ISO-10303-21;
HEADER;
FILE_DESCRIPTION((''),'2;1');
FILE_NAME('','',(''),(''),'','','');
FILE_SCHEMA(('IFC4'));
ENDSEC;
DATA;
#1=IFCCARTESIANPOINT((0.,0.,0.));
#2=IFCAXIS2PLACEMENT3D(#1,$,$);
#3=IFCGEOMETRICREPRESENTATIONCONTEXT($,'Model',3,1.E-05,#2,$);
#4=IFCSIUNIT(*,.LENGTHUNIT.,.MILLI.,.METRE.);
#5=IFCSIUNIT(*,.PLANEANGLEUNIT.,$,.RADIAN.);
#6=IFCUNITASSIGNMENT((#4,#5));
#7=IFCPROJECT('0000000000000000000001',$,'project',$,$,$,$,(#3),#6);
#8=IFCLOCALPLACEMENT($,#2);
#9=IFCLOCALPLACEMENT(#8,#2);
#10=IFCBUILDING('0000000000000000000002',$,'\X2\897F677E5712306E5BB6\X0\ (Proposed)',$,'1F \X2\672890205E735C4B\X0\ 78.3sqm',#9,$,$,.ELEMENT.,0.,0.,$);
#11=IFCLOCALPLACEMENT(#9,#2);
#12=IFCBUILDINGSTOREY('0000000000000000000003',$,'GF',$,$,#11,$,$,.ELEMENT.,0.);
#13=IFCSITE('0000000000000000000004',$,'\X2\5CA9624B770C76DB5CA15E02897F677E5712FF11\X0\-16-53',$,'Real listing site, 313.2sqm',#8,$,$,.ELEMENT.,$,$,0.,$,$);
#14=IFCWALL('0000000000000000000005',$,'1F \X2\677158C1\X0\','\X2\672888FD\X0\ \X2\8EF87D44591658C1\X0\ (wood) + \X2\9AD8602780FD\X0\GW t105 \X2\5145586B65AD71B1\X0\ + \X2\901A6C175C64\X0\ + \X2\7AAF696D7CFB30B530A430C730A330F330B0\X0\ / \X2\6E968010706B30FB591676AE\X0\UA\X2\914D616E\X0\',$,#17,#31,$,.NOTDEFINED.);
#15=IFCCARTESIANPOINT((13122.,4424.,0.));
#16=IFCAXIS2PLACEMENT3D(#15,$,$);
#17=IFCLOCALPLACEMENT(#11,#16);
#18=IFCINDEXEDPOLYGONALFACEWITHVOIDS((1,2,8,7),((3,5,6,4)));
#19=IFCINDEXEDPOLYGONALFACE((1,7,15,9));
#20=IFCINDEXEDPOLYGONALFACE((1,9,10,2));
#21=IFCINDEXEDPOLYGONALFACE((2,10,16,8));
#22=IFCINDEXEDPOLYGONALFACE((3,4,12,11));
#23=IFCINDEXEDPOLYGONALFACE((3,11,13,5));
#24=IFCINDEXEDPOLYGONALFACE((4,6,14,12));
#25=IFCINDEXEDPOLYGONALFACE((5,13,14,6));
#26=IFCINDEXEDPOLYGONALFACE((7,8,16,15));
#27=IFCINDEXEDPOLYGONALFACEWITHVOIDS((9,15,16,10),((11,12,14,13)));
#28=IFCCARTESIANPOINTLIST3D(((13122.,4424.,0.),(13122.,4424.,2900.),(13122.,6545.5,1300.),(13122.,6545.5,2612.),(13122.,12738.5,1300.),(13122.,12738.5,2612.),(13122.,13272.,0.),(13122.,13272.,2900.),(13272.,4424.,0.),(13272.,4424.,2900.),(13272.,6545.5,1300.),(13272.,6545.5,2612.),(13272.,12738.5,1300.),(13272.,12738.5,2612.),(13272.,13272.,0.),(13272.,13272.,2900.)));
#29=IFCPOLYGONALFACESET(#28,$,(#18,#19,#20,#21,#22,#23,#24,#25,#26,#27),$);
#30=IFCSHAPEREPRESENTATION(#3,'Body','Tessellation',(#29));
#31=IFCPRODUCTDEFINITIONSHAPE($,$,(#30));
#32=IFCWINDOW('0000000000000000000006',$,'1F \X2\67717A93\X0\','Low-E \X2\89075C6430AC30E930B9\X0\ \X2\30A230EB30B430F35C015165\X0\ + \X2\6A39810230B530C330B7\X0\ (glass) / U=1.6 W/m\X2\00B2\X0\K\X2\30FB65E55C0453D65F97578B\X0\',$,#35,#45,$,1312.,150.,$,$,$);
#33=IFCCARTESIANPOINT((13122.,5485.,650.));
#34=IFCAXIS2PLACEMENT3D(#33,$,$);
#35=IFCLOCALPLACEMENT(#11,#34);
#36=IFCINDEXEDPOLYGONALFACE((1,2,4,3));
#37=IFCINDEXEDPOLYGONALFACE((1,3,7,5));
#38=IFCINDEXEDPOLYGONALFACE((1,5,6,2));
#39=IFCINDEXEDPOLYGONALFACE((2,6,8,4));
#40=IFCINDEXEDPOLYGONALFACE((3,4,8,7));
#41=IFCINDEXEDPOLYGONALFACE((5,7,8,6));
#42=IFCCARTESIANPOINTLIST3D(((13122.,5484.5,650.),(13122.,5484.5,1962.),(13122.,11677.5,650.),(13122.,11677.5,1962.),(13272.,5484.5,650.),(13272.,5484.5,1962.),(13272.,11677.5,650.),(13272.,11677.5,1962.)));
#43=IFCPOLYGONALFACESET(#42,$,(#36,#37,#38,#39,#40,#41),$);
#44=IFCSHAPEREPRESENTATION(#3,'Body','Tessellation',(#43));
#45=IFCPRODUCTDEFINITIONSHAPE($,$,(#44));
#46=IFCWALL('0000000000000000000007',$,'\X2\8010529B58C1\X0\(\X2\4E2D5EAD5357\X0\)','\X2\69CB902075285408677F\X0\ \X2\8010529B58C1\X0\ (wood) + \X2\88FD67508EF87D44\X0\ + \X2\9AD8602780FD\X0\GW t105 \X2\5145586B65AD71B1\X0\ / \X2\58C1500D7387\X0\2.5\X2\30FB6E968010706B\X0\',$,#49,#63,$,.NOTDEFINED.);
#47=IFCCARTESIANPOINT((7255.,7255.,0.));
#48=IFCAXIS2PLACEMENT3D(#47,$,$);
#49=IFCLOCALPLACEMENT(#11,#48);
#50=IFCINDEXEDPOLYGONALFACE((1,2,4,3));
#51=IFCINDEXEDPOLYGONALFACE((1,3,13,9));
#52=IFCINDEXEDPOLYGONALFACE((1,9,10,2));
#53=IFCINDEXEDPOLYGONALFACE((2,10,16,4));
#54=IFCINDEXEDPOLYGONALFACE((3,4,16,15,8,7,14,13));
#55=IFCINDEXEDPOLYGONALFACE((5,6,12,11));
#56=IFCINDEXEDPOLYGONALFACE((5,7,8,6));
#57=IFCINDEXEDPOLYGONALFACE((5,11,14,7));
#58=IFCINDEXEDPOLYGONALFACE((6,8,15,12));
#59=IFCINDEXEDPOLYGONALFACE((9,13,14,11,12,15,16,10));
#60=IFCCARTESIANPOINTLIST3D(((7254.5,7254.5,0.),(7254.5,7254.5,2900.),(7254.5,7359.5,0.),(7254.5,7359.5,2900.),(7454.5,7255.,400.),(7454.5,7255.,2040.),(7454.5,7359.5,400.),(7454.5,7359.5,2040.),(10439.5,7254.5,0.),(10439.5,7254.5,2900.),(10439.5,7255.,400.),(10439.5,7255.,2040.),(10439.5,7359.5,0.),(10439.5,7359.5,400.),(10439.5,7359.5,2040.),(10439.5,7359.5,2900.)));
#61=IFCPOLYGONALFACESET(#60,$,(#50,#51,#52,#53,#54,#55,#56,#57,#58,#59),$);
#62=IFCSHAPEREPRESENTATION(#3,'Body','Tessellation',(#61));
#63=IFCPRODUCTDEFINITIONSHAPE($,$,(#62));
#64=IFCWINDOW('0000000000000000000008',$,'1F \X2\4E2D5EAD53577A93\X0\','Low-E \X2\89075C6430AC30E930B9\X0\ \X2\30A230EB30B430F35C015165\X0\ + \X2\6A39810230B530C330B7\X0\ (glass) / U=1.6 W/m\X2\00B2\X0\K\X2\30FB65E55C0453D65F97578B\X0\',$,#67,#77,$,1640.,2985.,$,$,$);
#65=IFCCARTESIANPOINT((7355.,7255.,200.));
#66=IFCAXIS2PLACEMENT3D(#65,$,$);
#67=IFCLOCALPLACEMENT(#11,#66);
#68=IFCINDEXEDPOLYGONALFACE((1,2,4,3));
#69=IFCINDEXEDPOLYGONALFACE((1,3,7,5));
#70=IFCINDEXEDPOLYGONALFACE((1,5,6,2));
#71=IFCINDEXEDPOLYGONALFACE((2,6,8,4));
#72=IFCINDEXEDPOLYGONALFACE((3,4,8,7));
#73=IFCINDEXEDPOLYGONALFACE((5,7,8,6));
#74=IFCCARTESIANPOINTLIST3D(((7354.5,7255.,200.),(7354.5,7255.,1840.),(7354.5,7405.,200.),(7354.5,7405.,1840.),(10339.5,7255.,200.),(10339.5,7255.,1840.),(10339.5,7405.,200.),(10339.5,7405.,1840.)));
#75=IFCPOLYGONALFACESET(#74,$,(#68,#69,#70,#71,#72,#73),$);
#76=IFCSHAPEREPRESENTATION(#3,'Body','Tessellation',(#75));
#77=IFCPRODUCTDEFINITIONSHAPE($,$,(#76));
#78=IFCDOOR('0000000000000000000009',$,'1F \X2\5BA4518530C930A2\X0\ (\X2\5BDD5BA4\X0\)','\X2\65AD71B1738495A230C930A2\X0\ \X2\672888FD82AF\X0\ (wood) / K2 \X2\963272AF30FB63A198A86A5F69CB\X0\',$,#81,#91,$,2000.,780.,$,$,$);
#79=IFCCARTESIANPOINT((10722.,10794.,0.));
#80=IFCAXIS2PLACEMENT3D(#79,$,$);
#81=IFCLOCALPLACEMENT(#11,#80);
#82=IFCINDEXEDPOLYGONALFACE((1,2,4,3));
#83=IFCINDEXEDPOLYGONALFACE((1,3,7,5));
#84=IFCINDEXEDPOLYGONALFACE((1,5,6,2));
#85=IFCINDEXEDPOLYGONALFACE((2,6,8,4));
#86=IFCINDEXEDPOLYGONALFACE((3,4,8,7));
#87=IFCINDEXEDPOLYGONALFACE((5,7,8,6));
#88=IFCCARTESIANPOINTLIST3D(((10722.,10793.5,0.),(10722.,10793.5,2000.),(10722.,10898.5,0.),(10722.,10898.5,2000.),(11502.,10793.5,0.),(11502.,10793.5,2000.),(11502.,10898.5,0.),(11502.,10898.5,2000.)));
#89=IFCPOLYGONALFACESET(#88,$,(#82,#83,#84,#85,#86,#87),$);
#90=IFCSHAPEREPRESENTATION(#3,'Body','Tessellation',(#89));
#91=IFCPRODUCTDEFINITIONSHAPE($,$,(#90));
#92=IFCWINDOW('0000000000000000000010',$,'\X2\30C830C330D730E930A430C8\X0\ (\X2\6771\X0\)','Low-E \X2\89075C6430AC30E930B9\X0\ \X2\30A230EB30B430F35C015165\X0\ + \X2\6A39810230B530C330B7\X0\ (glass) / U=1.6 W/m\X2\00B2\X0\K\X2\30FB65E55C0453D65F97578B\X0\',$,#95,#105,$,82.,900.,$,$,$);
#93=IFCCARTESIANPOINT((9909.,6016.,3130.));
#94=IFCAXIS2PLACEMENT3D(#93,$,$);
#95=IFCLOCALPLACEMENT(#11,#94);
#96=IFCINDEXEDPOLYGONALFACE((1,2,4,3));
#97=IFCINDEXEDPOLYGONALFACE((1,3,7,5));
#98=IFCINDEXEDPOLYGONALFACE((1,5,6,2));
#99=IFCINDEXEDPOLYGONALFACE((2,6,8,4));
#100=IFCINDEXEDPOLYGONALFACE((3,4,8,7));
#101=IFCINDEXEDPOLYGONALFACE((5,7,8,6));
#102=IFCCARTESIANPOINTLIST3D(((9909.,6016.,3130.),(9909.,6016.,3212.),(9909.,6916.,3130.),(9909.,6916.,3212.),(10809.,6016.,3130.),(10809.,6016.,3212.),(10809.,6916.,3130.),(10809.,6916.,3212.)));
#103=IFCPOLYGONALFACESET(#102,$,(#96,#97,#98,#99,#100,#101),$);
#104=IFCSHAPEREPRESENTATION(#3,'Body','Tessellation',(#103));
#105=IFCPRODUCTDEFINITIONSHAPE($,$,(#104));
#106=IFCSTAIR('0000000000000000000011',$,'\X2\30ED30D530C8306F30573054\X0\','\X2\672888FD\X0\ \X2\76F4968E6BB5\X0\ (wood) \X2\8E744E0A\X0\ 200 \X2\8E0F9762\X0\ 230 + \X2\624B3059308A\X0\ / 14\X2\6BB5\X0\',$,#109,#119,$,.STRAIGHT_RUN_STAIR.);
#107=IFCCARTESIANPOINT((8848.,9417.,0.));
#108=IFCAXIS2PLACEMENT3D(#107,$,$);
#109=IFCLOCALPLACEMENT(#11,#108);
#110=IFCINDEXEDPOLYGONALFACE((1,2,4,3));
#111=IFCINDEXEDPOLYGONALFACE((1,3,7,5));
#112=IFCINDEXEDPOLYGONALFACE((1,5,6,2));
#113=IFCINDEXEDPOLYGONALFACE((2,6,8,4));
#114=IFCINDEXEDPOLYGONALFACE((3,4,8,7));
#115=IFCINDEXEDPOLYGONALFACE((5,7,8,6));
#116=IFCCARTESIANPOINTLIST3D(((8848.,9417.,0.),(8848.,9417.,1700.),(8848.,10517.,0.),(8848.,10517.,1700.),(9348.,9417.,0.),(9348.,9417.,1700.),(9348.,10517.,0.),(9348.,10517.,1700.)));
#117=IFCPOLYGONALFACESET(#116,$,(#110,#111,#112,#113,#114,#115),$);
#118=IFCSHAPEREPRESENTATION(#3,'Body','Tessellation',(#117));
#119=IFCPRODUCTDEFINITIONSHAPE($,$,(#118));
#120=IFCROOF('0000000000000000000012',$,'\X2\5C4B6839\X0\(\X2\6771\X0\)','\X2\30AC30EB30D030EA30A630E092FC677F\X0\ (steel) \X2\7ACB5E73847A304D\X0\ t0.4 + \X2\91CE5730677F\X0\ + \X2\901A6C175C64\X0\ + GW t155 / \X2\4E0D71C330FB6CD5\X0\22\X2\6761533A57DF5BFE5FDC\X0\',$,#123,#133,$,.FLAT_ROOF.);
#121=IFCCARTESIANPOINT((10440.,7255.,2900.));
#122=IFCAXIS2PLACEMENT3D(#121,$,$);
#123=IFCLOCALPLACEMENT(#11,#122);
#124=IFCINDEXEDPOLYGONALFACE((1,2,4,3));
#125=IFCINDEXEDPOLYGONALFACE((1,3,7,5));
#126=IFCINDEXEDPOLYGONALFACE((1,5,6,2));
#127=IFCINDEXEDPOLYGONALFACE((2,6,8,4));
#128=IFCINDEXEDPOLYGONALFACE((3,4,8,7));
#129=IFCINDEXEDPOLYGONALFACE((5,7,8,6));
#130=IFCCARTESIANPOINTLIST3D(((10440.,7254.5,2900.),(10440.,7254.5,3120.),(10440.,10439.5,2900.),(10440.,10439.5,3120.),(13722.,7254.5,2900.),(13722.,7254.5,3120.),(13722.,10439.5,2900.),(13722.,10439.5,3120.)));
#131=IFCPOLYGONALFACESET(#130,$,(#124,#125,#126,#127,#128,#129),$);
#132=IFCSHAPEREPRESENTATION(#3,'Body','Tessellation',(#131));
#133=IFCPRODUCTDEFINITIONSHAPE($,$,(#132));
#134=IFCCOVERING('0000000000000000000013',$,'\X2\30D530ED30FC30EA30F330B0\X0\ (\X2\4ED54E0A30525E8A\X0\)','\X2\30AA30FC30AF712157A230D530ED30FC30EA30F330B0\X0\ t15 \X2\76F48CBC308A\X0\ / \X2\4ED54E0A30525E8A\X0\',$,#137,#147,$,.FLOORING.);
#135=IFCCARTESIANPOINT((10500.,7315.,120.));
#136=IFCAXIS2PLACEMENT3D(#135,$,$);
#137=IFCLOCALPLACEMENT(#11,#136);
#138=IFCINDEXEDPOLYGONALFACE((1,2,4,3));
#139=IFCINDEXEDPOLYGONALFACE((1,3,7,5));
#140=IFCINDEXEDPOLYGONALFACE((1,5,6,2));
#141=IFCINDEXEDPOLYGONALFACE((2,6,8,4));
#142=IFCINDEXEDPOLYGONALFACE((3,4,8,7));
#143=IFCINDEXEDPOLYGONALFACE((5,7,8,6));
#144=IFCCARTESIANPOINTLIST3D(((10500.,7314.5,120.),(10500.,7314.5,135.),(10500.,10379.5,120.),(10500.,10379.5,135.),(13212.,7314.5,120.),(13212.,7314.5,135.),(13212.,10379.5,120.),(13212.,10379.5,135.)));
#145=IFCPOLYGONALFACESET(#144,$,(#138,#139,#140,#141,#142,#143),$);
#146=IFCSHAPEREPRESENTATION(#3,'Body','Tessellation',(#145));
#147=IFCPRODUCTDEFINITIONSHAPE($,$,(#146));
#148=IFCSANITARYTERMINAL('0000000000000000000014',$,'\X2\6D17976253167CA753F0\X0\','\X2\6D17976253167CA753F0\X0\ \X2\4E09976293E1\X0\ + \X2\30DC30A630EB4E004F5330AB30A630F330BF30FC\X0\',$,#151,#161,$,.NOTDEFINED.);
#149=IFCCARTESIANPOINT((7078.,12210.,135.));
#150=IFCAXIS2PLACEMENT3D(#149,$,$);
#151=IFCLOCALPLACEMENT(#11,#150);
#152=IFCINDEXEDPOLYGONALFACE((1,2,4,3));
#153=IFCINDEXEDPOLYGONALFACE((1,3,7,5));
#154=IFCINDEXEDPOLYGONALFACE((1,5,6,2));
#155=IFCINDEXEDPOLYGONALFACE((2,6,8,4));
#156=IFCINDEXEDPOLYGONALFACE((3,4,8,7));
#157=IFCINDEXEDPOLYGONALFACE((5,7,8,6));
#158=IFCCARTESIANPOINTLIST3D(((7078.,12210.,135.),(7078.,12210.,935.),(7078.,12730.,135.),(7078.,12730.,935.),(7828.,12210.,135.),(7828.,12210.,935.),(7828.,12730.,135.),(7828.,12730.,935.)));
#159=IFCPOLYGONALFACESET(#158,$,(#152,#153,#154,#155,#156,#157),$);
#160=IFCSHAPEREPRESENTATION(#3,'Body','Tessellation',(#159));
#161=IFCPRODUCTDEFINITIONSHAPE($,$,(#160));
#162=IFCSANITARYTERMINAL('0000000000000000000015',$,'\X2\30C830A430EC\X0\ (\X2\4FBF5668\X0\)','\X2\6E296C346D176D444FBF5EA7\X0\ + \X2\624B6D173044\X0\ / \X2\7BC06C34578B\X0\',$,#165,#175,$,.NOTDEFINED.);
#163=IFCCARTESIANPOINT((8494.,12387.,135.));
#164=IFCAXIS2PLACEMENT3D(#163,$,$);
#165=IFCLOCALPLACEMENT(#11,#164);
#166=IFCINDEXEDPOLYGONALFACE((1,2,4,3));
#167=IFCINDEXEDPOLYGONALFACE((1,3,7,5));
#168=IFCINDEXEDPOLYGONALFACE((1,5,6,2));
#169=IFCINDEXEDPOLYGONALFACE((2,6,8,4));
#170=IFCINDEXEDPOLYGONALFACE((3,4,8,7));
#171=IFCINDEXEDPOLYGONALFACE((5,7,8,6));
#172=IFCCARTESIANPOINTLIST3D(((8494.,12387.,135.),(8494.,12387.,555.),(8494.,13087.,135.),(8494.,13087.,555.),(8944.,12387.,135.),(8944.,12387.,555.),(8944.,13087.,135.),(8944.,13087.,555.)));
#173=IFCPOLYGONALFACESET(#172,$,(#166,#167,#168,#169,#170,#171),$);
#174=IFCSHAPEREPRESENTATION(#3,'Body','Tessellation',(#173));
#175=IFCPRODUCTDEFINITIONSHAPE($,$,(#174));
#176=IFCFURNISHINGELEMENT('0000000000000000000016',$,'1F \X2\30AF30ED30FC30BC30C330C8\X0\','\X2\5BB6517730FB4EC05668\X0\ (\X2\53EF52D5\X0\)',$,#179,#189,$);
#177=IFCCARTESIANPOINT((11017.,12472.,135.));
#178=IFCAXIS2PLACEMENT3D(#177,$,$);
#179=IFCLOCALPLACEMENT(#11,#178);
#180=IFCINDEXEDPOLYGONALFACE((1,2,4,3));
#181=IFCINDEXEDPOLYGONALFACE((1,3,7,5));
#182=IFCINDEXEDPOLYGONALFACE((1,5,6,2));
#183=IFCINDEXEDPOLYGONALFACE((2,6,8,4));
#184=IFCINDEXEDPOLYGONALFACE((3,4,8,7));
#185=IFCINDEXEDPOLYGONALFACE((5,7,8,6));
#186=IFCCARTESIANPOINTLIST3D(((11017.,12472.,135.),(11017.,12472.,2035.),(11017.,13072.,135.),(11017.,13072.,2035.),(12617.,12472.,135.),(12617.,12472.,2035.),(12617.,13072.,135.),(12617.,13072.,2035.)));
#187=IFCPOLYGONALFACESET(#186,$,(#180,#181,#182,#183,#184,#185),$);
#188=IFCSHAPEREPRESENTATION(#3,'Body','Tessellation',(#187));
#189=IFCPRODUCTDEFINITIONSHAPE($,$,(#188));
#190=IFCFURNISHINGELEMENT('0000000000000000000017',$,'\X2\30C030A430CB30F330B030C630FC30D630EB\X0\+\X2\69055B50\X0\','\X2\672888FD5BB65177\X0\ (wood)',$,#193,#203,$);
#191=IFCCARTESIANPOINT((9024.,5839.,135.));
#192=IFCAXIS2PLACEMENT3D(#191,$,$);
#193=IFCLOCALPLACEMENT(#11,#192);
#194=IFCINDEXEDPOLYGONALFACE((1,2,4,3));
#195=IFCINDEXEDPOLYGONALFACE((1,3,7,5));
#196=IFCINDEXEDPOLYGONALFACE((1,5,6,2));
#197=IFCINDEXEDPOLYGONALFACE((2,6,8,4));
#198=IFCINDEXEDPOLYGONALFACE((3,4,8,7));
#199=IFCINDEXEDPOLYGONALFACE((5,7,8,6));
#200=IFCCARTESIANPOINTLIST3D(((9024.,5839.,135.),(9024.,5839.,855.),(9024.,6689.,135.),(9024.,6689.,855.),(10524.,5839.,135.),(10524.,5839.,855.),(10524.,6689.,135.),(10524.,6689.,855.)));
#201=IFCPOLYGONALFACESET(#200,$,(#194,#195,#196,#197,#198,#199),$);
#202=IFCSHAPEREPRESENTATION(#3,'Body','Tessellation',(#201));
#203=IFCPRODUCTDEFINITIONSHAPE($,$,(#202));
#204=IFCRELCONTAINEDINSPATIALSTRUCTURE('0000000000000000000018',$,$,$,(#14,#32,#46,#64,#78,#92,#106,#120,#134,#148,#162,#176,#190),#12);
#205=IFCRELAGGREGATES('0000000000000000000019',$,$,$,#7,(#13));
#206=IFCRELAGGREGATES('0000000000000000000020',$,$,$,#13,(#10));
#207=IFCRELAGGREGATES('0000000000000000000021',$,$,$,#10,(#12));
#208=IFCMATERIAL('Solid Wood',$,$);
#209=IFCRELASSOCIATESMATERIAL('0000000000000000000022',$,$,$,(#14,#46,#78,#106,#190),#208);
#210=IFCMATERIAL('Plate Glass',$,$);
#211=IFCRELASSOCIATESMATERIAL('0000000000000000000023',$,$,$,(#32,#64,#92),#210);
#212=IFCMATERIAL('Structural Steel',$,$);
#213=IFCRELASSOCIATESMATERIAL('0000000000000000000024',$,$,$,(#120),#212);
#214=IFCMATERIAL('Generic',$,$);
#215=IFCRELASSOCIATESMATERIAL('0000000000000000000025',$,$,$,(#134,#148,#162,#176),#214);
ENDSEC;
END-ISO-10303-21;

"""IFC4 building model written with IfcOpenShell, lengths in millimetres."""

from ifc_helpers import new_model, si_unit, frame, frame_2d, origin, place, context, project, spatial, rectangle, extrude, material, element, fill, save


model = new_model("IFC4")

# Units and contexts
model_context = context("Model", 3, precision=1e-05, world=origin())
ifc_project = project(units=[si_unit("LENGTHUNIT", "METRE", prefix="MILLI"), si_unit("PLANEANGLEUNIT", "RADIAN")], contexts=[model_context])

# Site, building, storey
site_placement = place(None, origin())
site = spatial("IfcSite", under=ifc_project, at=site_placement, Name="岩手県盛岡市西松園１-16-53", ObjectType="Real listing site, 313.2sqm", CompositionType="ELEMENT", RefElevation=0.0)
building_placement = place(site_placement, origin())
building = spatial("IfcBuilding", under=site, at=building_placement, Name="西松園の家 (Proposed)", ObjectType="1F 木造平屋 78.3sqm", CompositionType="ELEMENT", ElevationOfRefHeight=0.0, ElevationOfTerrain=0.0)
storey_placement = place(building_placement, origin())
storey = spatial("IfcBuildingStorey", under=building, at=storey_placement, Name="GF", CompositionType="ELEMENT", Elevation=0.0)

# Shared definitions
ifc_material_1 = material(Name="Solid Wood")

# Walls, openings, windows
wall_1_placement = place(storey_placement, frame((13122.0, 4424.0, 0.0)))
wall_1 = element("IfcWall", 1, at=wall_1_placement, inside=storey, material=ifc_material_1, Name="1F 東壁", Description="木製 軸組外壁 (wood) + 高性能GW t105 充填断熱 + 通気層 + 窯業系サイディング / 準耐火・外皮UA配慮", PredefinedType="NOTDEFINED", context=model_context, shape_type="SweptSolid", body=[
    extrude(rectangle(XDim=150.0, YDim=8848.0, at=frame_2d((75.0, 4424.0))), frame((13122.0, 4424.0, 0.0)), (0.0, 0.0, 1.0), 2900.0),
])
opening_1_placement = place(storey_placement, frame((13122.0, 5485.0, 650.0)))
opening_1 = element("IfcOpeningElement", 2, at=opening_1_placement, cuts=wall_1, PredefinedType="NOTDEFINED", context=model_context, shape_type="SweptSolid", body=[
    extrude(rectangle(XDim=150.0, YDim=6193.0, at=frame_2d((75.0, 3096.0))), frame((13122.0, 5485.0, 650.0)), (0.0, 0.0, 1.0), 1312.0),
])
ifc_material_2 = material(Name="Plate Glass")
window_1_placement = place(storey_placement, frame((13122.0, 5485.0, 650.0)))
window_1 = element("IfcWindow", 3, at=window_1_placement, inside=storey, material=ifc_material_2, Name="1F 東窓", Description="Low-E 複層ガラス アルゴン封入 + 樹脂サッシ (glass) / U=1.6 W/m²K・日射取得型", OverallHeight=1312.0, OverallWidth=150.0, context=model_context, shape_type="SweptSolid", body=[
    extrude(rectangle(XDim=150.0, YDim=6193.0, at=frame_2d((75.0, 3096.0))), frame((13122.0, 5485.0, 650.0)), (0.0, 0.0, 1.0), 1312.0),
])
fill(opening_1, window_1)
wall_2_placement = place(storey_placement, frame((7255.0, 7255.0, 0.0)))
wall_2 = element("IfcWall", 4, at=wall_2_placement, inside=storey, material=ifc_material_1, Name="耐力壁(中庭南)", Description="構造用合板 耐力壁 (wood) + 製材軸組 + 高性能GW t105 充填断熱 / 壁倍率2.5・準耐火", PredefinedType="NOTDEFINED", context=model_context, shape_type="SweptSolid", body=[
    extrude(rectangle(XDim=3185.0, YDim=105.0, at=frame_2d((1592.0, 52.0))), frame((7255.0, 7255.0, 0.0)), (0.0, 0.0, 1.0), 2900.0),
])
opening_2_placement = place(storey_placement, frame((7355.0, 7255.0, 200.0)))
opening_2 = element("IfcOpeningElement", 5, at=opening_2_placement, cuts=wall_2, PredefinedType="NOTDEFINED", context=model_context, shape_type="SweptSolid", body=[
    extrude(rectangle(XDim=2985.0, YDim=150.0, at=frame_2d((1492.0, 75.0))), frame((7355.0, 7255.0, 200.0)), (0.0, 0.0, 1.0), 1640.0),
])
window_2_placement = place(storey_placement, frame((7355.0, 7255.0, 200.0)))
window_2 = element("IfcWindow", 6, at=window_2_placement, inside=storey, material=ifc_material_2, Name="1F 中庭南窓", Description="Low-E 複層ガラス アルゴン封入 + 樹脂サッシ (glass) / U=1.6 W/m²K・日射取得型", OverallHeight=1640.0, OverallWidth=2985.0, context=model_context, shape_type="SweptSolid", body=[
    extrude(rectangle(XDim=2985.0, YDim=150.0, at=frame_2d((1492.0, 75.0))), frame((7355.0, 7255.0, 200.0)), (0.0, 0.0, 1.0), 1640.0),
])
fill(opening_2, window_2)

# Door
door_placement = place(storey_placement, frame((10722.0, 10794.0, 0.0)))
element("IfcDoor", 7, at=door_placement, inside=storey, material=ifc_material_1, Name="1F 室内ドア (寝室)", Description="断熱玄関ドア 木製芯 (wood) / K2 防犯・採風機構", OverallHeight=2000.0, OverallWidth=780.0, context=model_context, shape_type="SweptSolid", body=[
    extrude(rectangle(XDim=780.0, YDim=105.0, at=frame_2d((390.0, 52.0))), frame((10722.0, 10794.0, 0.0)), (0.0, 0.0, 1.0), 2000.0),
])

# Window
window_3_placement = place(storey_placement, frame((9909.0, 6016.0, 3130.0)))
element("IfcWindow", 8, at=window_3_placement, inside=storey, material=ifc_material_2, Name="トップライト (東)", Description="Low-E 複層ガラス アルゴン封入 + 樹脂サッシ (glass) / U=1.6 W/m²K・日射取得型", OverallHeight=82.0, OverallWidth=900.0, context=model_context, shape_type="SweptSolid", body=[
    extrude(rectangle(XDim=900.0, YDim=900.0, at=frame_2d((450.0, 450.0))), frame((9909.0, 6016.0, 3130.0)), (0.0, 0.0, 1.0), 82.0),
])

# Stair
stair_placement = place(storey_placement, frame((8848.0, 9417.0, 0.0)))
element("IfcStair", 9, at=stair_placement, inside=storey, material=ifc_material_1, Name="ロフトはしご", Description="木製 直階段 (wood) 蹴上 200 踏面 230 + 手すり / 14段", PredefinedType="STRAIGHT_RUN_STAIR", context=model_context, shape_type="SweptSolid", body=[
    extrude(rectangle(XDim=500.0, YDim=1100.0, at=frame_2d((250.0, 550.0))), frame((8848.0, 9417.0, 0.0)), (0.0, 0.0, 1.0), 1700.0),
])

# Roof
ifc_material_3 = material(Name="Structural Steel")
roof_placement = place(storey_placement, frame((10440.0, 7255.0, 2900.0)))
element("IfcRoof", 10, at=roof_placement, inside=storey, material=ifc_material_3, Name="屋根(東)", Description="ガルバリウム鋼板 (steel) 立平葺き t0.4 + 野地板 + 通気層 + GW t155 / 不燃・法22条区域対応", PredefinedType="FLAT_ROOF", context=model_context, shape_type="SweptSolid", body=[
    extrude(rectangle(XDim=3282.0, YDim=3185.0, at=frame_2d((1641.0, 1592.0))), frame((10440.0, 7255.0, 2900.0)), (0.0, 0.0, 1.0), 220.0),
])

# Covering
ifc_material_4 = material(Name="Generic")
covering_placement = place(storey_placement, frame((10500.0, 7315.0, 120.0)))
element("IfcCovering", 11, at=covering_placement, inside=storey, material=ifc_material_4, Name="フローリング (仕上げ床)", Description="オーク無垢フローリング t15 直貼り / 仕上げ床", PredefinedType="FLOORING", context=model_context, shape_type="SweptSolid", body=[
    extrude(rectangle(XDim=2712.0, YDim=3065.0, at=frame_2d((1356.0, 1532.0))), frame((10500.0, 7315.0, 120.0)), (0.0, 0.0, 1.0), 15.0),
])

# Sanitary terminals
sanitary_terminal_1_placement = place(storey_placement, frame((7078.0, 12210.0, 135.0)))
element("IfcSanitaryTerminal", 12, at=sanitary_terminal_1_placement, inside=storey, material=ifc_material_4, Name="洗面化粧台", Description="洗面化粧台 三面鏡 + ボウル一体カウンター", PredefinedType="NOTDEFINED", context=model_context, shape_type="SweptSolid", body=[
    extrude(rectangle(XDim=750.0, YDim=520.0, at=frame_2d((375.0, 260.0))), frame((7078.0, 12210.0, 135.0)), (0.0, 0.0, 1.0), 800.0),
])
sanitary_terminal_2_placement = place(storey_placement, frame((8494.0, 12387.0, 135.0)))
element("IfcSanitaryTerminal", 13, at=sanitary_terminal_2_placement, inside=storey, material=ifc_material_4, Name="トイレ (便器)", Description="温水洗浄便座 + 手洗い / 節水型", PredefinedType="NOTDEFINED", context=model_context, shape_type="SweptSolid", body=[
    extrude(rectangle(XDim=450.0, YDim=700.0, at=frame_2d((225.0, 350.0))), frame((8494.0, 12387.0, 135.0)), (0.0, 0.0, 1.0), 420.0),
])

# Furnishing elements
furnishing_1_placement = place(storey_placement, frame((11017.0, 12472.0, 135.0)))
element("IfcFurnishingElement", 14, at=furnishing_1_placement, inside=storey, material=ifc_material_4, Name="1F クローゼット", Description="家具・什器 (可動)", context=model_context, shape_type="SweptSolid", body=[
    extrude(rectangle(XDim=1600.0, YDim=600.0, at=frame_2d((800.0, 300.0))), frame((11017.0, 12472.0, 135.0)), (0.0, 0.0, 1.0), 1900.0),
])
furnishing_2_placement = place(storey_placement, frame((9024.0, 5839.0, 135.0)))
element("IfcFurnishingElement", 15, at=furnishing_2_placement, inside=storey, material=ifc_material_1, Name="ダイニングテーブル+椅子", Description="木製家具 (wood)", context=model_context, shape_type="SweptSolid", body=[
    extrude(rectangle(XDim=1500.0, YDim=850.0, at=frame_2d((750.0, 425.0))), frame((9024.0, 5839.0, 135.0)), (0.0, 0.0, 1.0), 720.0),
])

save(model, "model.ifc")
